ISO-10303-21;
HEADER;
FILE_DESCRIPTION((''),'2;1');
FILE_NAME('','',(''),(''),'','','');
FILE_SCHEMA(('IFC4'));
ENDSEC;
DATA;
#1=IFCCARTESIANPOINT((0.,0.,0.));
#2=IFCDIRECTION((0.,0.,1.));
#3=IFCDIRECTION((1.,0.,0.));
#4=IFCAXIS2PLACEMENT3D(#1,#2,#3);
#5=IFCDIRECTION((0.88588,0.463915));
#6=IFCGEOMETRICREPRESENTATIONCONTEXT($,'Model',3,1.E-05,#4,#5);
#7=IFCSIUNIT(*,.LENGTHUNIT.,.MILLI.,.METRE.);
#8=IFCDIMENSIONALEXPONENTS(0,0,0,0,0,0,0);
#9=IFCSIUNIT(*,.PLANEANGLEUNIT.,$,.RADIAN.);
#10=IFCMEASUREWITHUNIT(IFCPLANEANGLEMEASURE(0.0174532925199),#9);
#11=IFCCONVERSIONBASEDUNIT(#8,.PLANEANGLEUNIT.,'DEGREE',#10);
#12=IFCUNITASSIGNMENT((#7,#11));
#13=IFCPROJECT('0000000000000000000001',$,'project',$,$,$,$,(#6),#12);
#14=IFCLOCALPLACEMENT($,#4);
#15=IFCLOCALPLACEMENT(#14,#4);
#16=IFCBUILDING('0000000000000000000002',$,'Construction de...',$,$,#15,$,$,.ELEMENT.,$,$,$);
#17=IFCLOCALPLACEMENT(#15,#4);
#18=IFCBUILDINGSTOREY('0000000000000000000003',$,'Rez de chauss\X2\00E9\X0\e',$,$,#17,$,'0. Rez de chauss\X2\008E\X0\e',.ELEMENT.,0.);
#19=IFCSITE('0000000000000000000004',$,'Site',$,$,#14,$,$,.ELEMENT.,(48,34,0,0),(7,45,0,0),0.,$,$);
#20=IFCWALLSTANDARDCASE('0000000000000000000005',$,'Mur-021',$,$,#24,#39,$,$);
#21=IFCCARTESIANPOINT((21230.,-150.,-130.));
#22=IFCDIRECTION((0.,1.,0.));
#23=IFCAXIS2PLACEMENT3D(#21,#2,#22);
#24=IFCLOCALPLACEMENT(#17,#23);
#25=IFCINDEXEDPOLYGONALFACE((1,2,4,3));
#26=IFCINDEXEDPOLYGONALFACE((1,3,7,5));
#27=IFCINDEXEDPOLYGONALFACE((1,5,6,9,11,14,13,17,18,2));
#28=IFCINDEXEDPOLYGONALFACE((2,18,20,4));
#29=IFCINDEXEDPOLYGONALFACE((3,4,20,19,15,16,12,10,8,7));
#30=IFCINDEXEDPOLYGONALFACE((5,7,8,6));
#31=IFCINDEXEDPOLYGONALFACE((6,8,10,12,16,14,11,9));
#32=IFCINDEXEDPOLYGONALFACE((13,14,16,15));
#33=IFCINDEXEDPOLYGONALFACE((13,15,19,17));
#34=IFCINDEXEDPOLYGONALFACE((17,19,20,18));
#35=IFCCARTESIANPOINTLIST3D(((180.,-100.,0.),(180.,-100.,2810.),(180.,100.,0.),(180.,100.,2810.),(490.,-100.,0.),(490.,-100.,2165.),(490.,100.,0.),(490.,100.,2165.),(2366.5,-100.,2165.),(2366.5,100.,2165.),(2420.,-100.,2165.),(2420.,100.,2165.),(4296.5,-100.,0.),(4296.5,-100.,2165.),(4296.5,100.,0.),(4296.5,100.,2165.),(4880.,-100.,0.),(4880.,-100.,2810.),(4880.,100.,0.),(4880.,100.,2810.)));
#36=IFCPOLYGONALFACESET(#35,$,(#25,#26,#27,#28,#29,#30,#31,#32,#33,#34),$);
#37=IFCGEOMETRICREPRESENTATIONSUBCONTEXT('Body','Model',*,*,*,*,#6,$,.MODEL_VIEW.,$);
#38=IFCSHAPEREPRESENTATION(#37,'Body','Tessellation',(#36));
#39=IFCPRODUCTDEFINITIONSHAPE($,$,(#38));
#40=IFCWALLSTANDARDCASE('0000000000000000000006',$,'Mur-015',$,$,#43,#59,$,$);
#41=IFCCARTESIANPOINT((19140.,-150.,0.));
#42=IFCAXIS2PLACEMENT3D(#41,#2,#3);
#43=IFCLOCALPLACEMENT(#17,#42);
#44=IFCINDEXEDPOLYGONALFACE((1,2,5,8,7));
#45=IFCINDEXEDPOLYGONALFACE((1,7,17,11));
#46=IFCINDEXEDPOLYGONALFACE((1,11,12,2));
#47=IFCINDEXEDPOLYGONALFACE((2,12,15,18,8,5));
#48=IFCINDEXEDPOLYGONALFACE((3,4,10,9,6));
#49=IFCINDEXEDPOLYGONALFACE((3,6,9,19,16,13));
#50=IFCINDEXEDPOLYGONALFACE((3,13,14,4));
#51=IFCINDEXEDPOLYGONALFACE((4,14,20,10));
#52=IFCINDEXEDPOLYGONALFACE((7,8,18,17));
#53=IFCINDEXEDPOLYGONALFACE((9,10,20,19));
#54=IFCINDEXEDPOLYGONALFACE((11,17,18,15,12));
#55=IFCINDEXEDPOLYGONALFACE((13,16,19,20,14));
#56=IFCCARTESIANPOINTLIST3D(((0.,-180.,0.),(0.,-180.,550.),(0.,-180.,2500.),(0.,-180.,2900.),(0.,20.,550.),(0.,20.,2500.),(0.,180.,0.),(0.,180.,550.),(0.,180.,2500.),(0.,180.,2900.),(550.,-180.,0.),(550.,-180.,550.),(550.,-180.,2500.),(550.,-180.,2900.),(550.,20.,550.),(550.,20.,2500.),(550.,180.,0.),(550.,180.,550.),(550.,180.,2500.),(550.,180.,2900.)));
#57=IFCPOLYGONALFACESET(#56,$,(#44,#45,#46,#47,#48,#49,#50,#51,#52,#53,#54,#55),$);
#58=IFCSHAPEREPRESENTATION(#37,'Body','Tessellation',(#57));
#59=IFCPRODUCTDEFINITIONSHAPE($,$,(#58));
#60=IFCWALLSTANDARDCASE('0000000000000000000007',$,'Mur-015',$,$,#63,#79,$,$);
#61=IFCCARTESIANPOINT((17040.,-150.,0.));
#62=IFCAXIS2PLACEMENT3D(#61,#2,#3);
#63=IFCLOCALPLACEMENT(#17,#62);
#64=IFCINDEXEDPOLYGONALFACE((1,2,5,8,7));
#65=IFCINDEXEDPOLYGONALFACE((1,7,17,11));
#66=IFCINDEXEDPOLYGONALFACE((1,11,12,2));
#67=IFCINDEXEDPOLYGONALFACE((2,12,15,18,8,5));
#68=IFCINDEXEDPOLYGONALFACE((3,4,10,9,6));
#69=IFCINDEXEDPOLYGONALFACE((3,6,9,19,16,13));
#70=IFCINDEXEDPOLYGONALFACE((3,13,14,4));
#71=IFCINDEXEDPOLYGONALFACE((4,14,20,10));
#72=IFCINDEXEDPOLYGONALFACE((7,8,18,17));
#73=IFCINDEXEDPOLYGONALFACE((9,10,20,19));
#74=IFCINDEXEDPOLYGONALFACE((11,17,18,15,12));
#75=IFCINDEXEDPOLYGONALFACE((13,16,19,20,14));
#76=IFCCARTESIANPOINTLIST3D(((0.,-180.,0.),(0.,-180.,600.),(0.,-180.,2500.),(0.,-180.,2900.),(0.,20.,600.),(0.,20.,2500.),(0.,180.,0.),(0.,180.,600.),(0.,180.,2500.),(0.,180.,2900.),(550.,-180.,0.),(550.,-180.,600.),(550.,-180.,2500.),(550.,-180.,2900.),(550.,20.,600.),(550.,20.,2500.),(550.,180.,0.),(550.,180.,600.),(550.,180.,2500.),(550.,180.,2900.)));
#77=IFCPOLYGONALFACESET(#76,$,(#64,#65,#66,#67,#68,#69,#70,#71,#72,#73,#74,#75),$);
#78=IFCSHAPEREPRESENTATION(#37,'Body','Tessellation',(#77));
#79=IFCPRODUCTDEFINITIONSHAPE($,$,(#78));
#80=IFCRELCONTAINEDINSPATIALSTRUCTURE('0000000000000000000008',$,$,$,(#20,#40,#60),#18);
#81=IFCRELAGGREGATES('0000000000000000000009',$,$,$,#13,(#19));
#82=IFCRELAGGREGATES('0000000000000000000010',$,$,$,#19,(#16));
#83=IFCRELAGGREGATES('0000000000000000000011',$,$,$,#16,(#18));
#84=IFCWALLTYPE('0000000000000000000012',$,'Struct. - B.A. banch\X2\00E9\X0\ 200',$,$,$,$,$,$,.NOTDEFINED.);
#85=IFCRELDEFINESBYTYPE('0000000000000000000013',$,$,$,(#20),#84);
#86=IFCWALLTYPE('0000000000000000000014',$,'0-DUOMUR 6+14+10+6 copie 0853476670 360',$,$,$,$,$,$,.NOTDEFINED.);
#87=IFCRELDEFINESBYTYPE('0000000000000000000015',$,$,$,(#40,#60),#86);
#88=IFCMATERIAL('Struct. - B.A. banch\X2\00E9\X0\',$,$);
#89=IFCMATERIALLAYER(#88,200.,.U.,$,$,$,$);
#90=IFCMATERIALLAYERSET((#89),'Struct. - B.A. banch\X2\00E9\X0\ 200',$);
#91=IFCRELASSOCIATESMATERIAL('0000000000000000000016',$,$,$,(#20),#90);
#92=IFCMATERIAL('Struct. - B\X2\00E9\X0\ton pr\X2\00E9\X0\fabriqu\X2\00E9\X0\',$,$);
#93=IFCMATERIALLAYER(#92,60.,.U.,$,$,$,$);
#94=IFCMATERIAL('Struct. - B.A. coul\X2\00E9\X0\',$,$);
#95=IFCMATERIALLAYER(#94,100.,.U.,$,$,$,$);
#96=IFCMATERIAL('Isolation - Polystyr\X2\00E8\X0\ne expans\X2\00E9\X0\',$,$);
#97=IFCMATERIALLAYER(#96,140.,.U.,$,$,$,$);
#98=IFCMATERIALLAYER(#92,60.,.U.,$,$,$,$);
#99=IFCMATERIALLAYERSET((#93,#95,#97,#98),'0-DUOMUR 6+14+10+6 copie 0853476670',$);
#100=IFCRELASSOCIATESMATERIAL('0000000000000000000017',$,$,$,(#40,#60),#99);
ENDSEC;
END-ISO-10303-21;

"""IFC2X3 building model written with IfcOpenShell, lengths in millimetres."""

from ifc_helpers import new_model, entity, si_unit, converted_unit, direction, frame, origin_with_axes, origin_2d_with_axis, place, context, subcontext, project, spatial, polyline, rectangle, outline, extrude, clip, halfspace, material, layer, layer_set, layer_usage, type_object, element, save


model = new_model("IFC2X3")

# Units and contexts
model_context = context("Model", 3, precision=1e-05, world=origin_with_axes(), true_north=direction((0.88588, 0.463915)))
body_context = subcontext(model_context, "Body", "Model", "MODEL_VIEW")
ifc_project = project(units=[si_unit("LENGTHUNIT", "METRE", prefix="MILLI"), converted_unit("PLANEANGLEUNIT", "DEGREE", entity("IfcPlaneAngleMeasure", 0.0174532925199), si_unit("PLANEANGLEUNIT", "RADIAN"), dimensions=[0, 0, 0, 0, 0, 0, 0])], contexts=[model_context])

# Site, building, storey
site_placement = place(None, origin_with_axes())
site = spatial("IfcSite", under=ifc_project, at=site_placement, Name="Site", CompositionType="ELEMENT", RefLatitude=(48, 34, 0, 0), RefLongitude=(7, 45, 0, 0), RefElevation=0.0)
building_placement = place(site_placement, origin_with_axes())
building = spatial("IfcBuilding", under=site, at=building_placement, Name="Construction de...", CompositionType="ELEMENT")
storey_placement = place(building_placement, origin_with_axes())
storey = spatial("IfcBuildingStorey", under=building, at=storey_placement, Name="Rez de chaussée", LongName="0. Rez de chauss\u008ee", CompositionType="ELEMENT", Elevation=0.0)

# Shared definitions
ifc_material_1 = material(Name="Struct. - B.A. coulé")

# Wall, openings
ifc_material_2 = material(Name="Struct. - B.A. banché")
ifc_layer_1 = layer(ifc_material_2, 200.0, ventilated="UNKNOWN")
ifc_layer_set_1 = layer_set([ifc_layer_1], Name="Struct. - B.A. banché 200")
ifc_layer_usage_1 = layer_usage(ifc_layer_set_1, "AXIS2", "NEGATIVE", 100.0)
wall_type_1 = type_object("IfcWallType", Name="Struct. - B.A. banché 200", PredefinedType="NOTDEFINED")
wall_1_placement = place(storey_placement, frame((21230.0, -150.0, -130.0), z_axis=(0.0, 0.0, 1.0), x_axis=(0.0, 1.0, 0.0)))
wall_1 = element("IfcWallStandardCase", 1, at=wall_1_placement, inside=storey, type_object=wall_type_1, material=ifc_layer_usage_1, Name="Mur-021", context=body_context, shape_type="SweptSolid", body=[
    extrude(outline(polyline([(180.0, -100.0), (4880.0, -100.0), (4880.0, 100.0), (180.0, 100.0), (180.0, -100.0)])), origin_with_axes(), (0.0, 0.0, 1.0), 2810.0),
])
opening_1_placement = place(wall_1_placement, frame((1455.0, 0.0, 0.0), z_axis=(0.0, 0.0, 1.0), x_axis=(1.0, 0.0, 0.0)))
element("IfcOpeningElement", 2, at=opening_1_placement, cuts=wall_1, context=body_context, shape_type="SweptSolid", body=[
    extrude(rectangle(XDim=1930.0, YDim=2165.0, at=origin_2d_with_axis()), frame((0.0, 200.0, 1082.5), z_axis=(0.0, 1.0, 0.0), x_axis=(1.0, 0.0, 0.0)), (0.0, 0.0, -1.0), 600.0),
])
opening_2_placement = place(wall_1_placement, frame((3331.5, 0.0, 0.0), z_axis=(0.0, 0.0, 1.0), x_axis=(1.0, 0.0, 0.0)))
element("IfcOpeningElement", 3, at=opening_2_placement, cuts=wall_1, context=body_context, shape_type="SweptSolid", body=[
    extrude(rectangle(XDim=1930.0, YDim=2165.0, at=origin_2d_with_axis()), frame((0.0, 200.0, 1082.5), z_axis=(0.0, 1.0, 0.0), x_axis=(1.0, 0.0, 0.0)), (0.0, 0.0, -1.0), 600.0),
])

# Shared definitions
ifc_material_3 = material(Name="Struct. - Béton préfabriqué")
ifc_material_4 = material(Name="Isolation - Polystyrène expansé")

# Walls, openings
ifc_layer_2 = layer(ifc_material_3, 60.0, ventilated="UNKNOWN")
ifc_layer_3 = layer(ifc_material_1, 100.0, ventilated="UNKNOWN")
ifc_layer_4 = layer(ifc_material_4, 140.0, ventilated="UNKNOWN")
ifc_layer_5 = layer(ifc_material_3, 60.0, ventilated="UNKNOWN")
ifc_layer_set_2 = layer_set([ifc_layer_2, ifc_layer_3, ifc_layer_4, ifc_layer_5], Name="0-DUOMUR 6+14+10+6 copie 0853476670")
ifc_layer_usage_2 = layer_usage(ifc_layer_set_2, "AXIS2", "NEGATIVE", 180.0)
wall_type_2 = type_object("IfcWallType", Name="0-DUOMUR 6+14+10+6 copie 0853476670 360", PredefinedType="NOTDEFINED")
wall_2_placement = place(storey_placement, frame((19140.0, -150.0, 0.0), z_axis=(0.0, 0.0, 1.0), x_axis=(1.0, 0.0, 0.0)))
wall_2 = element("IfcWallStandardCase", 4, at=wall_2_placement, inside=storey, type_object=wall_type_2, material=ifc_layer_usage_2, Name="Mur-015", context=body_context, shape_type="Clipping", body=[
    clip(extrude(outline(polyline([(0.0, -180.0), (550.0, -180.0), (550.0, 180.0), (0.0, 180.0), (0.0, -180.0)])), origin_with_axes(), (0.0, 0.0, 1.0), 2900.0), halfspace(frame((-226.8, 0.0, 6048.6), z_axis=(0.037474, 0.0, -0.999298), x_axis=(0.0, 1.0, 0.0)), True)),
])
opening_3_placement = place(wall_2_placement, frame((275.0, 0.0, 550.0), z_axis=(0.0, 0.0, 1.0), x_axis=(1.0, 0.0, 0.0)))
element("IfcOpeningElement", 5, at=opening_3_placement, cuts=wall_2, context=body_context, shape_type="SweptSolid", body=[
    extrude(rectangle(XDim=550.0, YDim=1950.0, at=origin_2d_with_axis()), frame((0.0, 20.0, 975.0), z_axis=(0.0, 1.0, 0.0), x_axis=(-1.0, 0.0, 0.0)), (0.0, 0.0, -1.0), 560.0),
    extrude(rectangle(XDim=550.0, YDim=1950.0, at=origin_2d_with_axis()), frame((0.0, 20.0, 975.0), z_axis=(0.0, -1.0, 0.0), x_axis=(-1.0, 0.0, 0.0)), (0.0, 0.0, -1.0), 520.0),
])
ifc_layer_usage_3 = layer_usage(ifc_layer_set_2, "AXIS2", "NEGATIVE", 180.0)
wall_3_placement = place(storey_placement, frame((17040.0, -150.0, 0.0), z_axis=(0.0, 0.0, 1.0), x_axis=(1.0, 0.0, 0.0)))
wall_3 = element("IfcWallStandardCase", 6, at=wall_3_placement, inside=storey, type_object=wall_type_2, material=ifc_layer_usage_3, Name="Mur-015", context=body_context, shape_type="Clipping", body=[
    clip(extrude(outline(polyline([(0.0, -180.0), (550.0, -180.0), (550.0, 180.0), (0.0, 180.0), (0.0, -180.0)])), origin_with_axes(), (0.0, 0.0, 1.0), 2900.0), halfspace(frame((-223.9, 0.0, 5970.0), z_axis=(0.037474, 0.0, -0.999298), x_axis=(0.0, 1.0, 0.0)), True)),
])
opening_4_placement = place(wall_3_placement, frame((275.0, 0.0, 600.0), z_axis=(0.0, 0.0, 1.0), x_axis=(1.0, 0.0, 0.0)))
element("IfcOpeningElement", 7, at=opening_4_placement, cuts=wall_3, context=body_context, shape_type="SweptSolid", body=[
    extrude(rectangle(XDim=550.0, YDim=1900.0, at=origin_2d_with_axis()), frame((0.0, 20.0, 950.0), z_axis=(0.0, 1.0, 0.0), x_axis=(-1.0, 0.0, 0.0)), (0.0, 0.0, -1.0), 560.0),
    extrude(rectangle(XDim=550.0, YDim=1900.0, at=origin_2d_with_axis()), frame((0.0, 20.0, 950.0), z_axis=(0.0, -1.0, 0.0), x_axis=(-1.0, 0.0, 0.0)), (0.0, 0.0, -1.0), 520.0),
])

save(model, "model.ifc")
